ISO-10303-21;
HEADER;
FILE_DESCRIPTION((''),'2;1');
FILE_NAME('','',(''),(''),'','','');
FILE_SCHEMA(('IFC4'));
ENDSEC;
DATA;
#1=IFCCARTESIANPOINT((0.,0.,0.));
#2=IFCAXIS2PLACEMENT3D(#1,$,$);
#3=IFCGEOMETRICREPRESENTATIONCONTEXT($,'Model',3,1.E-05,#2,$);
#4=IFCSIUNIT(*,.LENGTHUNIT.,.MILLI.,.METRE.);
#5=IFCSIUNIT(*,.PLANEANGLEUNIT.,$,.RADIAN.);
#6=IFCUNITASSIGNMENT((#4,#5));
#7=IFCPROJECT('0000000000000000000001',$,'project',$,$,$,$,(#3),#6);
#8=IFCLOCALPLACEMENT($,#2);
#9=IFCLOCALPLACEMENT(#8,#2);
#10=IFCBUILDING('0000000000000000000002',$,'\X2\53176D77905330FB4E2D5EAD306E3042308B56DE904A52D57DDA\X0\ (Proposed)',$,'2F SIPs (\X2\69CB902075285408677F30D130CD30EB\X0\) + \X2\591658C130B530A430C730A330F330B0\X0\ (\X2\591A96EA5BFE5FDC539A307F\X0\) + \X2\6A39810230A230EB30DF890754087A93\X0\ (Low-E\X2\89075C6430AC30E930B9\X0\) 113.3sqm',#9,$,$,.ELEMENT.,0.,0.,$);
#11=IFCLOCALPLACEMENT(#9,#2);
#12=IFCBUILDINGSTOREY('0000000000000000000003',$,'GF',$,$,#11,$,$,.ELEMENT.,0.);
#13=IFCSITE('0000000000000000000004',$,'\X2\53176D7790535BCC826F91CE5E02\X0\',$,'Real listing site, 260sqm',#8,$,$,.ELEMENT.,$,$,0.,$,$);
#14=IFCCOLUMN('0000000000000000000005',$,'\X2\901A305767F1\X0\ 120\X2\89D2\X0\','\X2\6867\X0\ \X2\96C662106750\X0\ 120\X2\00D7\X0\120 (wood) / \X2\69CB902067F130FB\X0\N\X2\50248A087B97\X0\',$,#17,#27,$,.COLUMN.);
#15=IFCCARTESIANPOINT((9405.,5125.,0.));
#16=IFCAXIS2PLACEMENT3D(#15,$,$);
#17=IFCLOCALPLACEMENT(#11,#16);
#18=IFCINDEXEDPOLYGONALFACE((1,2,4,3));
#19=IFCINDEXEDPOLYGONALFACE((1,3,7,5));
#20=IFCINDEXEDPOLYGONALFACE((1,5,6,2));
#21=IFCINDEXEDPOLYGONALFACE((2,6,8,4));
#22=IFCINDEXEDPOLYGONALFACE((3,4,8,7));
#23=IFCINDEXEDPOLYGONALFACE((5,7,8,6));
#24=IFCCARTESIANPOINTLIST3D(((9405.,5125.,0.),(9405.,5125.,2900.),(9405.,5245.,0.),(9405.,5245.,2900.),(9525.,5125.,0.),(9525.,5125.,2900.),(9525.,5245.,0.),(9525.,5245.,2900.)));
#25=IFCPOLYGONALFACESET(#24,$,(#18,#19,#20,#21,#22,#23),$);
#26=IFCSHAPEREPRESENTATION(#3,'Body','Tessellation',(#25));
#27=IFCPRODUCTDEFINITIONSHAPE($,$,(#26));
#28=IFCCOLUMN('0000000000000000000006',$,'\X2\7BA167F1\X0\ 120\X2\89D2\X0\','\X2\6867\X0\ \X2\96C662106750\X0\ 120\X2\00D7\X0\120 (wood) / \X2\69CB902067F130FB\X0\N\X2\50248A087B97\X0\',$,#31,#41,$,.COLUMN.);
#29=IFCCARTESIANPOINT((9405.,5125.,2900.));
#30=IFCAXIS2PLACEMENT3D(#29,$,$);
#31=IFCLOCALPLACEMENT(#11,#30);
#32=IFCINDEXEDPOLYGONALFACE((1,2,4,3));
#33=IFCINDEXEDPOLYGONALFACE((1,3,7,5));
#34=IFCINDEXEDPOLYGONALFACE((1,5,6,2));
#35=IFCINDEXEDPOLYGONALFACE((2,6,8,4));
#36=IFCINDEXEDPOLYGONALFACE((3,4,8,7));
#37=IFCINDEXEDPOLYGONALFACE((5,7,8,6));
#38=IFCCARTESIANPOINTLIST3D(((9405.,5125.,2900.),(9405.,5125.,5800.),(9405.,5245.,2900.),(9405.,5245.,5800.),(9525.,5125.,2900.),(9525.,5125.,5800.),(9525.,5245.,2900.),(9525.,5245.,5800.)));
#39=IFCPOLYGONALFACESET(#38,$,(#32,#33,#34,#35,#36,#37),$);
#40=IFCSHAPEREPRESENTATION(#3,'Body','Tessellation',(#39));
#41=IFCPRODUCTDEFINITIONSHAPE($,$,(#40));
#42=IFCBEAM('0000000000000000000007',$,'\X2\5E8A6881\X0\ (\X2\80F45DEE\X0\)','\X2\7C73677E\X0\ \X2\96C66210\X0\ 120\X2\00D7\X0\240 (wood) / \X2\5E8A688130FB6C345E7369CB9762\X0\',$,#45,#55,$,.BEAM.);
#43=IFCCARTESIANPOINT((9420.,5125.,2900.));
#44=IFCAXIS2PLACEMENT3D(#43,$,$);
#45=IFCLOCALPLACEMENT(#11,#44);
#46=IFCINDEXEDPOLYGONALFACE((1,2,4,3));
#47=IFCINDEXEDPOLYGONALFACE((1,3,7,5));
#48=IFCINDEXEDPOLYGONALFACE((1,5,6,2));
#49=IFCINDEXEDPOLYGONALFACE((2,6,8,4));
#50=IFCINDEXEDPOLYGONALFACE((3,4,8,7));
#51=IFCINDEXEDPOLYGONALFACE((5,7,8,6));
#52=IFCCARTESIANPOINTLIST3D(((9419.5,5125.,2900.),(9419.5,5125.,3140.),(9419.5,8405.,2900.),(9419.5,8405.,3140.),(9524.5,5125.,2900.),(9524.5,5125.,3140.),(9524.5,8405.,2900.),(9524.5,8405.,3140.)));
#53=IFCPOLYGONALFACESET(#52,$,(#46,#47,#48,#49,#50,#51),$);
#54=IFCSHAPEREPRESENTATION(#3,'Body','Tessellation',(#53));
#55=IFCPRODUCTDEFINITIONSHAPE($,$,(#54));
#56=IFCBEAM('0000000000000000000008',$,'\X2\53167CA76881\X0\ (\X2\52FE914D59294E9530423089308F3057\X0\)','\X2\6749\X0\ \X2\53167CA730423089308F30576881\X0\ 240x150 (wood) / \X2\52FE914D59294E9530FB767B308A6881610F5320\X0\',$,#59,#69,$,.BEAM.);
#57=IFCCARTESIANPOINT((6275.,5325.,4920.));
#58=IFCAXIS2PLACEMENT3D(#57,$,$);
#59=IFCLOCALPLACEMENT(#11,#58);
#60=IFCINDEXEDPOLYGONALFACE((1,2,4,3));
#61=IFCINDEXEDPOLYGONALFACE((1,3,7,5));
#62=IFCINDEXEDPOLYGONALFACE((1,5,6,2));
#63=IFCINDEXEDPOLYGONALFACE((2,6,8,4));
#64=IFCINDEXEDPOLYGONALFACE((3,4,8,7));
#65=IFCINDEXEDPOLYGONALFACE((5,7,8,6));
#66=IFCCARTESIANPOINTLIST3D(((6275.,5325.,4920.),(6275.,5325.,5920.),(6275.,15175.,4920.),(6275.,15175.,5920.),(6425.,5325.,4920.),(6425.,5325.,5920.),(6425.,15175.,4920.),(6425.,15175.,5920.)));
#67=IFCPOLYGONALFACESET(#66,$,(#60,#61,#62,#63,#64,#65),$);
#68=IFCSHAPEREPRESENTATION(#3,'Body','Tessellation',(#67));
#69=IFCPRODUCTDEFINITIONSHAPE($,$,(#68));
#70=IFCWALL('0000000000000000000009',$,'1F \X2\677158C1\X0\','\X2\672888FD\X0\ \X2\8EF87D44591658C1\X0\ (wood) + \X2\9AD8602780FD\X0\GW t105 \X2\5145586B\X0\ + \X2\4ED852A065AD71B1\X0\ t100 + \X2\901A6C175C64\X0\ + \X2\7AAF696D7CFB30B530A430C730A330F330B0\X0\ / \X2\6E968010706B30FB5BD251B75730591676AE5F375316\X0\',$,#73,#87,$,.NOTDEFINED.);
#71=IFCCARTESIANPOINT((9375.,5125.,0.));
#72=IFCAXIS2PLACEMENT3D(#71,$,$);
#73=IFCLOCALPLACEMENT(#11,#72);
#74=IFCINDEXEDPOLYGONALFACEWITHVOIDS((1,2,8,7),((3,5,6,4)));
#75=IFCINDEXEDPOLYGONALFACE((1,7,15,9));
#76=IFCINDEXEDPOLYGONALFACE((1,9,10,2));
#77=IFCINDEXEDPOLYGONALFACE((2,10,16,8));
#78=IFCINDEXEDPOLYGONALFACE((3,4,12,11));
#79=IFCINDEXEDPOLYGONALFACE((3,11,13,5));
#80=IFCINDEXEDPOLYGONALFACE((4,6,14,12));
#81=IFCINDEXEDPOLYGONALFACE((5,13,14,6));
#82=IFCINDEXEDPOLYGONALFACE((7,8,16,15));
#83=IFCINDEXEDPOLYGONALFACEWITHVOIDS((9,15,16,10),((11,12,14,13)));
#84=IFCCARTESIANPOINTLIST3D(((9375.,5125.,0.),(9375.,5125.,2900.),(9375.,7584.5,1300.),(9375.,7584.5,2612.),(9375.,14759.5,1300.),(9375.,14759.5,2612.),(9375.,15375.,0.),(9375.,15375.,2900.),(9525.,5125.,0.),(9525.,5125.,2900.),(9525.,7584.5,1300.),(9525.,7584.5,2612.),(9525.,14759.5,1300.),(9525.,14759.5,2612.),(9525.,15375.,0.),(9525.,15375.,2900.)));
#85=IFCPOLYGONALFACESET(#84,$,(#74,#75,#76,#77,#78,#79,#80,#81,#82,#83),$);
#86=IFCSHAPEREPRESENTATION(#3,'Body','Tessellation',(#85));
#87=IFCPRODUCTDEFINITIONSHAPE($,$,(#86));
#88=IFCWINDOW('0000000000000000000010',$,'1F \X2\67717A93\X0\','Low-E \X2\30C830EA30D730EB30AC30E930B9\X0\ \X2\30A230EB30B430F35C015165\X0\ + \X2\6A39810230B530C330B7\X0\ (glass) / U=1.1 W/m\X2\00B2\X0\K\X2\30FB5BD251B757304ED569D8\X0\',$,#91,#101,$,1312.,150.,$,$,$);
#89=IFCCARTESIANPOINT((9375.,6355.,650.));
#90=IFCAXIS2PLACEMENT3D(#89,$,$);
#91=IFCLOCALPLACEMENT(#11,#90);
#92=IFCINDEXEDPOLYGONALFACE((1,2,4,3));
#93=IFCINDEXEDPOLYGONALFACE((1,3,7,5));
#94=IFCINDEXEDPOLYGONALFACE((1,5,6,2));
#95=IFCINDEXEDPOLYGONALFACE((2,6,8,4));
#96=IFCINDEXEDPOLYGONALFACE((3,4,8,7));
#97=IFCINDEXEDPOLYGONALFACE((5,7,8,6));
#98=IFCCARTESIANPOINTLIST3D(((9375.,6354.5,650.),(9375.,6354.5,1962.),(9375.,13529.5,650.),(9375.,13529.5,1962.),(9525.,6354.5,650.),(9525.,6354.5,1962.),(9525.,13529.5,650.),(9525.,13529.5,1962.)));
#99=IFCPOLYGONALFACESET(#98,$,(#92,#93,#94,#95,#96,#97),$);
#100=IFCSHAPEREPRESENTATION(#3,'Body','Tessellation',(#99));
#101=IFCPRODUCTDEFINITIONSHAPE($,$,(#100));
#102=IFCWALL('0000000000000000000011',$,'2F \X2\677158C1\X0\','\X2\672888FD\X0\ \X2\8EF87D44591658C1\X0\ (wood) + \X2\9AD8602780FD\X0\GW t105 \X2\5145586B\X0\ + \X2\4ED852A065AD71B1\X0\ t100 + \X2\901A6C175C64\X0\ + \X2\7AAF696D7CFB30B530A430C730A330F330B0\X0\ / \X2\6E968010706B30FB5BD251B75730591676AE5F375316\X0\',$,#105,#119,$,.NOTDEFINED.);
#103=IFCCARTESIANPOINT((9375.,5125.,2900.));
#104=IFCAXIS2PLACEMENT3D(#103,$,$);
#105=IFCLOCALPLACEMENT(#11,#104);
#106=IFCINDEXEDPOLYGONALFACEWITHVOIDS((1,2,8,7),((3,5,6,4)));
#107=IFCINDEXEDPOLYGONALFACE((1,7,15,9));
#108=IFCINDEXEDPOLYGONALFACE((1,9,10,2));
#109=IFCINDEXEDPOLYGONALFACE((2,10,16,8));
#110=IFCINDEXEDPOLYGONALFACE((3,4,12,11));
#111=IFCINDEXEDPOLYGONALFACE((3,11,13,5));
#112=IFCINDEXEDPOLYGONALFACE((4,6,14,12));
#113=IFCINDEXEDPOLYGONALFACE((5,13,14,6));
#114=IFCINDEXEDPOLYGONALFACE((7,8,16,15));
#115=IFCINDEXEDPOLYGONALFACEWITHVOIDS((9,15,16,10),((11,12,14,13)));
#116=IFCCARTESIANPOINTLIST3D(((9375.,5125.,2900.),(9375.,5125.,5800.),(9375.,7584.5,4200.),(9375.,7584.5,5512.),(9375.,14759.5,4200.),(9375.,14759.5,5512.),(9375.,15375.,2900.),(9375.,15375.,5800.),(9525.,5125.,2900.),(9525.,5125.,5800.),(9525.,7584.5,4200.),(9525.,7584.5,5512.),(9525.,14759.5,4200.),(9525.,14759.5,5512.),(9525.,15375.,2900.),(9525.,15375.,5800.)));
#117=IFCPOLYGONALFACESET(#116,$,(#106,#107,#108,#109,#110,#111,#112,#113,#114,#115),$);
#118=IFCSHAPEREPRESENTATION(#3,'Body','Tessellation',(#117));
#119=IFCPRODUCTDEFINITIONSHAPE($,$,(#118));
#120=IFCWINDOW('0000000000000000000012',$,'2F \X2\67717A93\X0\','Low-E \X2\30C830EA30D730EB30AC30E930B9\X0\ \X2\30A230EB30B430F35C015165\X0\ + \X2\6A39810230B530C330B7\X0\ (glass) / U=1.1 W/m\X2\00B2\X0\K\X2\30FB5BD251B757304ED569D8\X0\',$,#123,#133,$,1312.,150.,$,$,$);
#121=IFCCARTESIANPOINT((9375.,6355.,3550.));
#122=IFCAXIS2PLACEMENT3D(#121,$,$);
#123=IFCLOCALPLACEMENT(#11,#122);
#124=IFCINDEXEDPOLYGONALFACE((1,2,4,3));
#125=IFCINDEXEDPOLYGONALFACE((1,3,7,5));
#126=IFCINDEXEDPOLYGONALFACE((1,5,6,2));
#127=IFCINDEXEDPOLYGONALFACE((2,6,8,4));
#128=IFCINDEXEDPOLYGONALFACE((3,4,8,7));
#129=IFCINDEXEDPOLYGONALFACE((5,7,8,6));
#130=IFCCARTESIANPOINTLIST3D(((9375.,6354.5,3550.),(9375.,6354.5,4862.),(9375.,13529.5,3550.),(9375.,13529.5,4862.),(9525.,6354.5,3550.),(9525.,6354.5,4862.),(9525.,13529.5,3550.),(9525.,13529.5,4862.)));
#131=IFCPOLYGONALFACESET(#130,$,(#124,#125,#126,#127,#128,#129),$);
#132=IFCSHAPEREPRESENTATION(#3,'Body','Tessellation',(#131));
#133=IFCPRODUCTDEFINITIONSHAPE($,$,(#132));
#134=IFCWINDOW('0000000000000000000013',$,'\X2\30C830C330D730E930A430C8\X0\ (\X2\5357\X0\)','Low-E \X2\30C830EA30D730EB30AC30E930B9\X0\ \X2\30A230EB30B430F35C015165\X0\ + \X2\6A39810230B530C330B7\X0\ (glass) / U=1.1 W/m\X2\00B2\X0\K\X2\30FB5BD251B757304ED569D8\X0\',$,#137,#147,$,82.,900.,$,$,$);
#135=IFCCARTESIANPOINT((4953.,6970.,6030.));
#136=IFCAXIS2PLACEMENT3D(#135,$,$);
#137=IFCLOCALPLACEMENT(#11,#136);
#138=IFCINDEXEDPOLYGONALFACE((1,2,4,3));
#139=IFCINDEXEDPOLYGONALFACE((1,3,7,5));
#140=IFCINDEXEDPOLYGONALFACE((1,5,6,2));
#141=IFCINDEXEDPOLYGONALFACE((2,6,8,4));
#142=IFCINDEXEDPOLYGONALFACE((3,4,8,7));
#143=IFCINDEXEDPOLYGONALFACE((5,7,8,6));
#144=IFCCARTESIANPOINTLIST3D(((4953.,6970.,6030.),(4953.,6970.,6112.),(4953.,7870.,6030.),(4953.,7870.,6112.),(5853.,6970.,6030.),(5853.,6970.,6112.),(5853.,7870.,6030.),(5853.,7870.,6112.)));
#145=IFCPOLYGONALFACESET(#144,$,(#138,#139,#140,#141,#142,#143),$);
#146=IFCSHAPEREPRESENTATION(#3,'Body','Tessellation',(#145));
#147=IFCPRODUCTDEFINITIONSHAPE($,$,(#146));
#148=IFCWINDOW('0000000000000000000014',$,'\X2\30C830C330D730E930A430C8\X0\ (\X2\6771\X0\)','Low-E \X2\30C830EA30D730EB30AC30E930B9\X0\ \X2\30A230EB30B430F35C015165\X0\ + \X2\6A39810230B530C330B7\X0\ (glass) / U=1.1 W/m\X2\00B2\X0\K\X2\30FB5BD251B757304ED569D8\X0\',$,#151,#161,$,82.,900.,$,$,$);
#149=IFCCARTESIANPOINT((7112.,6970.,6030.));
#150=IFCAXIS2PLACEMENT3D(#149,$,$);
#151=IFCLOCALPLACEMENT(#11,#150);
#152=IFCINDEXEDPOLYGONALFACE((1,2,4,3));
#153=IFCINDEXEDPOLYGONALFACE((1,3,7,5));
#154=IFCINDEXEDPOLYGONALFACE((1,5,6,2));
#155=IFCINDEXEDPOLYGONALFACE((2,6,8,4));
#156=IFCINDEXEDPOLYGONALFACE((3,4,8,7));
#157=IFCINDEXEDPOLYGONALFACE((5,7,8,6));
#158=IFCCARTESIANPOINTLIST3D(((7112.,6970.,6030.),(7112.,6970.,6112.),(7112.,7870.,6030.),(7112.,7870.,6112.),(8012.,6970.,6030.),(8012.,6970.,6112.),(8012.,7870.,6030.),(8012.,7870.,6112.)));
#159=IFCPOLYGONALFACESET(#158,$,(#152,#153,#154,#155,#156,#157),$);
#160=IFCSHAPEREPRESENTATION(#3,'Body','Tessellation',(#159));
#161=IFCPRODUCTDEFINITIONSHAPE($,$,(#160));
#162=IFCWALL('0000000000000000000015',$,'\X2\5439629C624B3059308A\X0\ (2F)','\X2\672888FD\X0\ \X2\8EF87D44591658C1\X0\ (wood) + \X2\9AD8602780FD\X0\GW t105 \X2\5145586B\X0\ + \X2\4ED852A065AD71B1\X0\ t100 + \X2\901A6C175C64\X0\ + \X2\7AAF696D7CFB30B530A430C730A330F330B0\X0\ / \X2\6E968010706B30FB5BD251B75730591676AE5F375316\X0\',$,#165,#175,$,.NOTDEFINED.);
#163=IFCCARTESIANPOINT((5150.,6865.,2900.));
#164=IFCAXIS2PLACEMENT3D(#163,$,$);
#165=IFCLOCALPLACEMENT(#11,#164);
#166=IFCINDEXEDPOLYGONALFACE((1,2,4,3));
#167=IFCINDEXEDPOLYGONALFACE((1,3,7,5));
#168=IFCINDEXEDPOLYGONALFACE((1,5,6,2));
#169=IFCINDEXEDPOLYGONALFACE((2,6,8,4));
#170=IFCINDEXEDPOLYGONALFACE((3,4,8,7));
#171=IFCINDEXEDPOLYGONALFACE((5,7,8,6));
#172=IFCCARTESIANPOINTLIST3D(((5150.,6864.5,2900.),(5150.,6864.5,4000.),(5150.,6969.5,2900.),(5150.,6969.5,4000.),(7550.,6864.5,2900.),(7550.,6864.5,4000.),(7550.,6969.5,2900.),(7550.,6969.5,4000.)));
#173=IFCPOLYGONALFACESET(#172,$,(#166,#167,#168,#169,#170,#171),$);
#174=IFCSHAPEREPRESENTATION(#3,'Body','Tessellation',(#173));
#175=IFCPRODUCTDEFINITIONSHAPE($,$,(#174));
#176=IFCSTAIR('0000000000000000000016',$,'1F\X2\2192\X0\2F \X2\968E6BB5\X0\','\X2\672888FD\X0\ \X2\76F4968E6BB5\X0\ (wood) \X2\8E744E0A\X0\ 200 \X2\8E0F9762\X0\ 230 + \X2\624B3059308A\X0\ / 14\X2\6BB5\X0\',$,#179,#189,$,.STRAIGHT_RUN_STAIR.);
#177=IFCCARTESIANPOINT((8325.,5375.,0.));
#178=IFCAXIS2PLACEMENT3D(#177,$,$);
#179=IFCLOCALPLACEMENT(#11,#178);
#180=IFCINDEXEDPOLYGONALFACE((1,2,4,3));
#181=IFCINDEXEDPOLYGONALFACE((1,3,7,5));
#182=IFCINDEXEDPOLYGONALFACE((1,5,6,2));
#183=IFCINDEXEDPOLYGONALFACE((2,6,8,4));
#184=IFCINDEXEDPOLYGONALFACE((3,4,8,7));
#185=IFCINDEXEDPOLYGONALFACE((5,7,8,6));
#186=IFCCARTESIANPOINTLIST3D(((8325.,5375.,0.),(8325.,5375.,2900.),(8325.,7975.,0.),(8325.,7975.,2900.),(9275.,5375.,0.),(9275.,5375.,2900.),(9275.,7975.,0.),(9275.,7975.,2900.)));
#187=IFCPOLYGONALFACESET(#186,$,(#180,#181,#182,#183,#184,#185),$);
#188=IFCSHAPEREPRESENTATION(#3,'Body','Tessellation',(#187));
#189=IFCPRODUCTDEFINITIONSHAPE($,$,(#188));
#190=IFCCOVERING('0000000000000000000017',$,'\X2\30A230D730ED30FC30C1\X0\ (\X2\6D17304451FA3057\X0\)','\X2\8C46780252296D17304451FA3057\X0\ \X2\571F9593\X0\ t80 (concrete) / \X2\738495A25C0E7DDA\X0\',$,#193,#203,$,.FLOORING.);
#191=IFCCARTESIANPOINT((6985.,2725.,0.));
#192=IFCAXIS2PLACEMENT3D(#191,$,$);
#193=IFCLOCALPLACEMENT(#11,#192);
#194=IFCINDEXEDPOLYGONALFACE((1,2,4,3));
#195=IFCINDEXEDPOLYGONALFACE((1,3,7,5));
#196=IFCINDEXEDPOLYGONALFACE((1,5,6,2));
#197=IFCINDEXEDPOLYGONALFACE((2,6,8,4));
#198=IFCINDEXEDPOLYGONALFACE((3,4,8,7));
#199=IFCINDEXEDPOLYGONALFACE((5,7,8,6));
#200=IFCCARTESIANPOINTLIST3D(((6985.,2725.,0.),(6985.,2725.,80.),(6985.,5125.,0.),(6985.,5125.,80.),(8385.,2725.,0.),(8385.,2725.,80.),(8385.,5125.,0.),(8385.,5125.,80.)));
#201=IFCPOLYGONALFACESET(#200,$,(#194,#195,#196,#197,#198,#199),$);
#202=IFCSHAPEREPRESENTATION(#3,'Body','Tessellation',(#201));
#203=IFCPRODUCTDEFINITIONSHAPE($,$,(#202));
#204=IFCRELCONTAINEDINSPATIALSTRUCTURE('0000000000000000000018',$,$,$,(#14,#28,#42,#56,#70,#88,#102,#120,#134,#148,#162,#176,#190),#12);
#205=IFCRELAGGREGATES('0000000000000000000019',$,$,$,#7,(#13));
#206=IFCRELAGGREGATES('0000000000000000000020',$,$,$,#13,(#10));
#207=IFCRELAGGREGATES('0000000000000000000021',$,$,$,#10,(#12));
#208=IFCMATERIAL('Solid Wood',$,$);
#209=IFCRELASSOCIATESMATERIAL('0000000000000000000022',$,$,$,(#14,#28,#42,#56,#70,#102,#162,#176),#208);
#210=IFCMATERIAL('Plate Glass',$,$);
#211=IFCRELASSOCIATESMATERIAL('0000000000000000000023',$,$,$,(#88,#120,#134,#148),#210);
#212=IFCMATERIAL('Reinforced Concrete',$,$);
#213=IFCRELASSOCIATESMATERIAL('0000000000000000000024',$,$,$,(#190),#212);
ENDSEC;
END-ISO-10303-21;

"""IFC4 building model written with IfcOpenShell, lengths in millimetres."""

from ifc_helpers import new_model, si_unit, frame, frame_2d, origin, place, context, project, spatial, rectangle, extrude, material, element, fill, save


model = new_model("IFC4")

# Units and contexts
model_context = context("Model", 3, precision=1e-05, world=origin())
ifc_project = project(units=[si_unit("LENGTHUNIT", "METRE", prefix="MILLI"), si_unit("PLANEANGLEUNIT", "RADIAN")], contexts=[model_context])

# Site, building, storey
site_placement = place(None, origin())
site = spatial("IfcSite", under=ifc_project, at=site_placement, Name="北海道富良野市", ObjectType="Real listing site, 260sqm", CompositionType="ELEMENT", RefElevation=0.0)
building_placement = place(site_placement, origin())
building = spatial("IfcBuilding", under=site, at=building_placement, Name="北海道・中庭のある回遊動線 (Proposed)", ObjectType="2F SIPs (構造用合板パネル) + 外壁サイディング (多雪対応厚み) + 樹脂アルミ複合窓 (Low-E複層ガラス) 113.3sqm", CompositionType="ELEMENT", ElevationOfRefHeight=0.0, ElevationOfTerrain=0.0)
storey_placement = place(building_placement, origin())
storey = spatial("IfcBuildingStorey", under=building, at=storey_placement, Name="GF", CompositionType="ELEMENT", Elevation=0.0)

# Columns
ifc_material_1 = material(Name="Solid Wood")
column_1_placement = place(storey_placement, frame((9405.0, 5125.0, 0.0)))
element("IfcColumn", 1, at=column_1_placement, inside=storey, material=ifc_material_1, Name="通し柱 120角", Description="桧 集成材 120×120 (wood) / 構造柱・N値計算", PredefinedType="COLUMN", context=model_context, shape_type="SweptSolid", body=[
    extrude(rectangle(XDim=120.0, YDim=120.0, at=frame_2d((60.0, 60.0))), frame((9405.0, 5125.0, 0.0)), (0.0, 0.0, 1.0), 2900.0),
])
column_2_placement = place(storey_placement, frame((9405.0, 5125.0, 2900.0)))
element("IfcColumn", 2, at=column_2_placement, inside=storey, material=ifc_material_1, Name="管柱 120角", Description="桧 集成材 120×120 (wood) / 構造柱・N値計算", PredefinedType="COLUMN", context=model_context, shape_type="SweptSolid", body=[
    extrude(rectangle(XDim=120.0, YDim=120.0, at=frame_2d((60.0, 60.0))), frame((9405.0, 5125.0, 2900.0)), (0.0, 0.0, 1.0), 2900.0),
])

# Beams
beam_1_placement = place(storey_placement, frame((9420.0, 5125.0, 2900.0)))
element("IfcBeam", 3, at=beam_1_placement, inside=storey, material=ifc_material_1, Name="床梁 (胴差)", Description="米松 集成 120×240 (wood) / 床梁・水平構面", PredefinedType="BEAM", context=model_context, shape_type="SweptSolid", body=[
    extrude(rectangle(XDim=105.0, YDim=3280.0, at=frame_2d((52.0, 1640.0))), frame((9420.0, 5125.0, 2900.0)), (0.0, 0.0, 1.0), 240.0),
])
beam_2_placement = place(storey_placement, frame((6275.0, 5325.0, 4920.0)))
element("IfcBeam", 4, at=beam_2_placement, inside=storey, material=ifc_material_1, Name="化粧梁 (勾配天井あらわし)", Description="杉 化粧あらわし梁 240x150 (wood) / 勾配天井・登り梁意匠", PredefinedType="BEAM", context=model_context, shape_type="SweptSolid", body=[
    extrude(rectangle(XDim=150.0, YDim=9850.0, at=frame_2d((75.0, 4925.0))), frame((6275.0, 5325.0, 4920.0)), (0.0, 0.0, 1.0), 1000.0),
])

# Wall, opening, window
wall_1_placement = place(storey_placement, frame((9375.0, 5125.0, 0.0)))
wall_1 = element("IfcWall", 5, at=wall_1_placement, inside=storey, material=ifc_material_1, Name="1F 東壁", Description="木製 軸組外壁 (wood) + 高性能GW t105 充填 + 付加断熱 t100 + 通気層 + 窯業系サイディング / 準耐火・寒冷地外皮強化", PredefinedType="NOTDEFINED", context=model_context, shape_type="SweptSolid", body=[
    extrude(rectangle(XDim=150.0, YDim=10250.0, at=frame_2d((75.0, 5125.0))), frame((9375.0, 5125.0, 0.0)), (0.0, 0.0, 1.0), 2900.0),
])
opening_1_placement = place(storey_placement, frame((9375.0, 6355.0, 650.0)))
opening_1 = element("IfcOpeningElement", 6, at=opening_1_placement, cuts=wall_1, PredefinedType="NOTDEFINED", context=model_context, shape_type="SweptSolid", body=[
    extrude(rectangle(XDim=150.0, YDim=7175.0, at=frame_2d((75.0, 3587.0))), frame((9375.0, 6355.0, 650.0)), (0.0, 0.0, 1.0), 1312.0),
])
ifc_material_2 = material(Name="Plate Glass")
window_1_placement = place(storey_placement, frame((9375.0, 6355.0, 650.0)))
window_1 = element("IfcWindow", 7, at=window_1_placement, inside=storey, material=ifc_material_2, Name="1F 東窓", Description="Low-E トリプルガラス アルゴン封入 + 樹脂サッシ (glass) / U=1.1 W/m²K・寒冷地仕様", OverallHeight=1312.0, OverallWidth=150.0, context=model_context, shape_type="SweptSolid", body=[
    extrude(rectangle(XDim=150.0, YDim=7175.0, at=frame_2d((75.0, 3587.0))), frame((9375.0, 6355.0, 650.0)), (0.0, 0.0, 1.0), 1312.0),
])
fill(opening_1, window_1)

# Wall, opening, window
wall_2_placement = place(storey_placement, frame((9375.0, 5125.0, 2900.0)))
wall_2 = element("IfcWall", 8, at=wall_2_placement, inside=storey, material=ifc_material_1, Name="2F 東壁", Description="木製 軸組外壁 (wood) + 高性能GW t105 充填 + 付加断熱 t100 + 通気層 + 窯業系サイディング / 準耐火・寒冷地外皮強化", PredefinedType="NOTDEFINED", context=model_context, shape_type="SweptSolid", body=[
    extrude(rectangle(XDim=150.0, YDim=10250.0, at=frame_2d((75.0, 5125.0))), frame((9375.0, 5125.0, 2900.0)), (0.0, 0.0, 1.0), 2900.0),
])
opening_2_placement = place(storey_placement, frame((9375.0, 6355.0, 3550.0)))
opening_2 = element("IfcOpeningElement", 9, at=opening_2_placement, cuts=wall_2, PredefinedType="NOTDEFINED", context=model_context, shape_type="SweptSolid", body=[
    extrude(rectangle(XDim=150.0, YDim=7175.0, at=frame_2d((75.0, 3587.0))), frame((9375.0, 6355.0, 3550.0)), (0.0, 0.0, 1.0), 1312.0),
])
window_2_placement = place(storey_placement, frame((9375.0, 6355.0, 3550.0)))
window_2 = element("IfcWindow", 10, at=window_2_placement, inside=storey, material=ifc_material_2, Name="2F 東窓", Description="Low-E トリプルガラス アルゴン封入 + 樹脂サッシ (glass) / U=1.1 W/m²K・寒冷地仕様", OverallHeight=1312.0, OverallWidth=150.0, context=model_context, shape_type="SweptSolid", body=[
    extrude(rectangle(XDim=150.0, YDim=7175.0, at=frame_2d((75.0, 3587.0))), frame((9375.0, 6355.0, 3550.0)), (0.0, 0.0, 1.0), 1312.0),
])
fill(opening_2, window_2)

# Windows
window_3_placement = place(storey_placement, frame((4953.0, 6970.0, 6030.0)))
element("IfcWindow", 11, at=window_3_placement, inside=storey, material=ifc_material_2, Name="トップライト (南)", Description="Low-E トリプルガラス アルゴン封入 + 樹脂サッシ (glass) / U=1.1 W/m²K・寒冷地仕様", OverallHeight=82.0, OverallWidth=900.0, context=model_context, shape_type="SweptSolid", body=[
    extrude(rectangle(XDim=900.0, YDim=900.0, at=frame_2d((450.0, 450.0))), frame((4953.0, 6970.0, 6030.0)), (0.0, 0.0, 1.0), 82.0),
])
window_4_placement = place(storey_placement, frame((7112.0, 6970.0, 6030.0)))
element("IfcWindow", 12, at=window_4_placement, inside=storey, material=ifc_material_2, Name="トップライト (東)", Description="Low-E トリプルガラス アルゴン封入 + 樹脂サッシ (glass) / U=1.1 W/m²K・寒冷地仕様", OverallHeight=82.0, OverallWidth=900.0, context=model_context, shape_type="SweptSolid", body=[
    extrude(rectangle(XDim=900.0, YDim=900.0, at=frame_2d((450.0, 450.0))), frame((7112.0, 6970.0, 6030.0)), (0.0, 0.0, 1.0), 82.0),
])

# Wall
wall_3_placement = place(storey_placement, frame((5150.0, 6865.0, 2900.0)))
element("IfcWall", 13, at=wall_3_placement, inside=storey, material=ifc_material_1, Name="吹抜手すり (2F)", Description="木製 軸組外壁 (wood) + 高性能GW t105 充填 + 付加断熱 t100 + 通気層 + 窯業系サイディング / 準耐火・寒冷地外皮強化", PredefinedType="NOTDEFINED", context=model_context, shape_type="SweptSolid", body=[
    extrude(rectangle(XDim=2400.0, YDim=105.0, at=frame_2d((1200.0, 52.0))), frame((5150.0, 6865.0, 2900.0)), (0.0, 0.0, 1.0), 1100.0),
])

# Stair
stair_placement = place(storey_placement, frame((8325.0, 5375.0, 0.0)))
element("IfcStair", 14, at=stair_placement, inside=storey, material=ifc_material_1, Name="1F→2F 階段", Description="木製 直階段 (wood) 蹴上 200 踏面 230 + 手すり / 14段", PredefinedType="STRAIGHT_RUN_STAIR", context=model_context, shape_type="SweptSolid", body=[
    extrude(rectangle(XDim=950.0, YDim=2600.0, at=frame_2d((475.0, 1300.0))), frame((8325.0, 5375.0, 0.0)), (0.0, 0.0, 1.0), 2900.0),
])

# Covering
ifc_material_3 = material(Name="Reinforced Concrete")
covering_placement = place(storey_placement, frame((6985.0, 2725.0, 0.0)))
element("IfcCovering", 15, at=covering_placement, inside=storey, material=ifc_material_3, Name="アプローチ (洗い出し)", Description="豆砂利洗い出し 土間 t80 (concrete) / 玄関導線", PredefinedType="FLOORING", context=model_context, shape_type="SweptSolid", body=[
    extrude(rectangle(XDim=1400.0, YDim=2400.0, at=frame_2d((700.0, 1200.0))), frame((6985.0, 2725.0, 0.0)), (0.0, 0.0, 1.0), 80.0),
])

save(model, "model.ifc")
